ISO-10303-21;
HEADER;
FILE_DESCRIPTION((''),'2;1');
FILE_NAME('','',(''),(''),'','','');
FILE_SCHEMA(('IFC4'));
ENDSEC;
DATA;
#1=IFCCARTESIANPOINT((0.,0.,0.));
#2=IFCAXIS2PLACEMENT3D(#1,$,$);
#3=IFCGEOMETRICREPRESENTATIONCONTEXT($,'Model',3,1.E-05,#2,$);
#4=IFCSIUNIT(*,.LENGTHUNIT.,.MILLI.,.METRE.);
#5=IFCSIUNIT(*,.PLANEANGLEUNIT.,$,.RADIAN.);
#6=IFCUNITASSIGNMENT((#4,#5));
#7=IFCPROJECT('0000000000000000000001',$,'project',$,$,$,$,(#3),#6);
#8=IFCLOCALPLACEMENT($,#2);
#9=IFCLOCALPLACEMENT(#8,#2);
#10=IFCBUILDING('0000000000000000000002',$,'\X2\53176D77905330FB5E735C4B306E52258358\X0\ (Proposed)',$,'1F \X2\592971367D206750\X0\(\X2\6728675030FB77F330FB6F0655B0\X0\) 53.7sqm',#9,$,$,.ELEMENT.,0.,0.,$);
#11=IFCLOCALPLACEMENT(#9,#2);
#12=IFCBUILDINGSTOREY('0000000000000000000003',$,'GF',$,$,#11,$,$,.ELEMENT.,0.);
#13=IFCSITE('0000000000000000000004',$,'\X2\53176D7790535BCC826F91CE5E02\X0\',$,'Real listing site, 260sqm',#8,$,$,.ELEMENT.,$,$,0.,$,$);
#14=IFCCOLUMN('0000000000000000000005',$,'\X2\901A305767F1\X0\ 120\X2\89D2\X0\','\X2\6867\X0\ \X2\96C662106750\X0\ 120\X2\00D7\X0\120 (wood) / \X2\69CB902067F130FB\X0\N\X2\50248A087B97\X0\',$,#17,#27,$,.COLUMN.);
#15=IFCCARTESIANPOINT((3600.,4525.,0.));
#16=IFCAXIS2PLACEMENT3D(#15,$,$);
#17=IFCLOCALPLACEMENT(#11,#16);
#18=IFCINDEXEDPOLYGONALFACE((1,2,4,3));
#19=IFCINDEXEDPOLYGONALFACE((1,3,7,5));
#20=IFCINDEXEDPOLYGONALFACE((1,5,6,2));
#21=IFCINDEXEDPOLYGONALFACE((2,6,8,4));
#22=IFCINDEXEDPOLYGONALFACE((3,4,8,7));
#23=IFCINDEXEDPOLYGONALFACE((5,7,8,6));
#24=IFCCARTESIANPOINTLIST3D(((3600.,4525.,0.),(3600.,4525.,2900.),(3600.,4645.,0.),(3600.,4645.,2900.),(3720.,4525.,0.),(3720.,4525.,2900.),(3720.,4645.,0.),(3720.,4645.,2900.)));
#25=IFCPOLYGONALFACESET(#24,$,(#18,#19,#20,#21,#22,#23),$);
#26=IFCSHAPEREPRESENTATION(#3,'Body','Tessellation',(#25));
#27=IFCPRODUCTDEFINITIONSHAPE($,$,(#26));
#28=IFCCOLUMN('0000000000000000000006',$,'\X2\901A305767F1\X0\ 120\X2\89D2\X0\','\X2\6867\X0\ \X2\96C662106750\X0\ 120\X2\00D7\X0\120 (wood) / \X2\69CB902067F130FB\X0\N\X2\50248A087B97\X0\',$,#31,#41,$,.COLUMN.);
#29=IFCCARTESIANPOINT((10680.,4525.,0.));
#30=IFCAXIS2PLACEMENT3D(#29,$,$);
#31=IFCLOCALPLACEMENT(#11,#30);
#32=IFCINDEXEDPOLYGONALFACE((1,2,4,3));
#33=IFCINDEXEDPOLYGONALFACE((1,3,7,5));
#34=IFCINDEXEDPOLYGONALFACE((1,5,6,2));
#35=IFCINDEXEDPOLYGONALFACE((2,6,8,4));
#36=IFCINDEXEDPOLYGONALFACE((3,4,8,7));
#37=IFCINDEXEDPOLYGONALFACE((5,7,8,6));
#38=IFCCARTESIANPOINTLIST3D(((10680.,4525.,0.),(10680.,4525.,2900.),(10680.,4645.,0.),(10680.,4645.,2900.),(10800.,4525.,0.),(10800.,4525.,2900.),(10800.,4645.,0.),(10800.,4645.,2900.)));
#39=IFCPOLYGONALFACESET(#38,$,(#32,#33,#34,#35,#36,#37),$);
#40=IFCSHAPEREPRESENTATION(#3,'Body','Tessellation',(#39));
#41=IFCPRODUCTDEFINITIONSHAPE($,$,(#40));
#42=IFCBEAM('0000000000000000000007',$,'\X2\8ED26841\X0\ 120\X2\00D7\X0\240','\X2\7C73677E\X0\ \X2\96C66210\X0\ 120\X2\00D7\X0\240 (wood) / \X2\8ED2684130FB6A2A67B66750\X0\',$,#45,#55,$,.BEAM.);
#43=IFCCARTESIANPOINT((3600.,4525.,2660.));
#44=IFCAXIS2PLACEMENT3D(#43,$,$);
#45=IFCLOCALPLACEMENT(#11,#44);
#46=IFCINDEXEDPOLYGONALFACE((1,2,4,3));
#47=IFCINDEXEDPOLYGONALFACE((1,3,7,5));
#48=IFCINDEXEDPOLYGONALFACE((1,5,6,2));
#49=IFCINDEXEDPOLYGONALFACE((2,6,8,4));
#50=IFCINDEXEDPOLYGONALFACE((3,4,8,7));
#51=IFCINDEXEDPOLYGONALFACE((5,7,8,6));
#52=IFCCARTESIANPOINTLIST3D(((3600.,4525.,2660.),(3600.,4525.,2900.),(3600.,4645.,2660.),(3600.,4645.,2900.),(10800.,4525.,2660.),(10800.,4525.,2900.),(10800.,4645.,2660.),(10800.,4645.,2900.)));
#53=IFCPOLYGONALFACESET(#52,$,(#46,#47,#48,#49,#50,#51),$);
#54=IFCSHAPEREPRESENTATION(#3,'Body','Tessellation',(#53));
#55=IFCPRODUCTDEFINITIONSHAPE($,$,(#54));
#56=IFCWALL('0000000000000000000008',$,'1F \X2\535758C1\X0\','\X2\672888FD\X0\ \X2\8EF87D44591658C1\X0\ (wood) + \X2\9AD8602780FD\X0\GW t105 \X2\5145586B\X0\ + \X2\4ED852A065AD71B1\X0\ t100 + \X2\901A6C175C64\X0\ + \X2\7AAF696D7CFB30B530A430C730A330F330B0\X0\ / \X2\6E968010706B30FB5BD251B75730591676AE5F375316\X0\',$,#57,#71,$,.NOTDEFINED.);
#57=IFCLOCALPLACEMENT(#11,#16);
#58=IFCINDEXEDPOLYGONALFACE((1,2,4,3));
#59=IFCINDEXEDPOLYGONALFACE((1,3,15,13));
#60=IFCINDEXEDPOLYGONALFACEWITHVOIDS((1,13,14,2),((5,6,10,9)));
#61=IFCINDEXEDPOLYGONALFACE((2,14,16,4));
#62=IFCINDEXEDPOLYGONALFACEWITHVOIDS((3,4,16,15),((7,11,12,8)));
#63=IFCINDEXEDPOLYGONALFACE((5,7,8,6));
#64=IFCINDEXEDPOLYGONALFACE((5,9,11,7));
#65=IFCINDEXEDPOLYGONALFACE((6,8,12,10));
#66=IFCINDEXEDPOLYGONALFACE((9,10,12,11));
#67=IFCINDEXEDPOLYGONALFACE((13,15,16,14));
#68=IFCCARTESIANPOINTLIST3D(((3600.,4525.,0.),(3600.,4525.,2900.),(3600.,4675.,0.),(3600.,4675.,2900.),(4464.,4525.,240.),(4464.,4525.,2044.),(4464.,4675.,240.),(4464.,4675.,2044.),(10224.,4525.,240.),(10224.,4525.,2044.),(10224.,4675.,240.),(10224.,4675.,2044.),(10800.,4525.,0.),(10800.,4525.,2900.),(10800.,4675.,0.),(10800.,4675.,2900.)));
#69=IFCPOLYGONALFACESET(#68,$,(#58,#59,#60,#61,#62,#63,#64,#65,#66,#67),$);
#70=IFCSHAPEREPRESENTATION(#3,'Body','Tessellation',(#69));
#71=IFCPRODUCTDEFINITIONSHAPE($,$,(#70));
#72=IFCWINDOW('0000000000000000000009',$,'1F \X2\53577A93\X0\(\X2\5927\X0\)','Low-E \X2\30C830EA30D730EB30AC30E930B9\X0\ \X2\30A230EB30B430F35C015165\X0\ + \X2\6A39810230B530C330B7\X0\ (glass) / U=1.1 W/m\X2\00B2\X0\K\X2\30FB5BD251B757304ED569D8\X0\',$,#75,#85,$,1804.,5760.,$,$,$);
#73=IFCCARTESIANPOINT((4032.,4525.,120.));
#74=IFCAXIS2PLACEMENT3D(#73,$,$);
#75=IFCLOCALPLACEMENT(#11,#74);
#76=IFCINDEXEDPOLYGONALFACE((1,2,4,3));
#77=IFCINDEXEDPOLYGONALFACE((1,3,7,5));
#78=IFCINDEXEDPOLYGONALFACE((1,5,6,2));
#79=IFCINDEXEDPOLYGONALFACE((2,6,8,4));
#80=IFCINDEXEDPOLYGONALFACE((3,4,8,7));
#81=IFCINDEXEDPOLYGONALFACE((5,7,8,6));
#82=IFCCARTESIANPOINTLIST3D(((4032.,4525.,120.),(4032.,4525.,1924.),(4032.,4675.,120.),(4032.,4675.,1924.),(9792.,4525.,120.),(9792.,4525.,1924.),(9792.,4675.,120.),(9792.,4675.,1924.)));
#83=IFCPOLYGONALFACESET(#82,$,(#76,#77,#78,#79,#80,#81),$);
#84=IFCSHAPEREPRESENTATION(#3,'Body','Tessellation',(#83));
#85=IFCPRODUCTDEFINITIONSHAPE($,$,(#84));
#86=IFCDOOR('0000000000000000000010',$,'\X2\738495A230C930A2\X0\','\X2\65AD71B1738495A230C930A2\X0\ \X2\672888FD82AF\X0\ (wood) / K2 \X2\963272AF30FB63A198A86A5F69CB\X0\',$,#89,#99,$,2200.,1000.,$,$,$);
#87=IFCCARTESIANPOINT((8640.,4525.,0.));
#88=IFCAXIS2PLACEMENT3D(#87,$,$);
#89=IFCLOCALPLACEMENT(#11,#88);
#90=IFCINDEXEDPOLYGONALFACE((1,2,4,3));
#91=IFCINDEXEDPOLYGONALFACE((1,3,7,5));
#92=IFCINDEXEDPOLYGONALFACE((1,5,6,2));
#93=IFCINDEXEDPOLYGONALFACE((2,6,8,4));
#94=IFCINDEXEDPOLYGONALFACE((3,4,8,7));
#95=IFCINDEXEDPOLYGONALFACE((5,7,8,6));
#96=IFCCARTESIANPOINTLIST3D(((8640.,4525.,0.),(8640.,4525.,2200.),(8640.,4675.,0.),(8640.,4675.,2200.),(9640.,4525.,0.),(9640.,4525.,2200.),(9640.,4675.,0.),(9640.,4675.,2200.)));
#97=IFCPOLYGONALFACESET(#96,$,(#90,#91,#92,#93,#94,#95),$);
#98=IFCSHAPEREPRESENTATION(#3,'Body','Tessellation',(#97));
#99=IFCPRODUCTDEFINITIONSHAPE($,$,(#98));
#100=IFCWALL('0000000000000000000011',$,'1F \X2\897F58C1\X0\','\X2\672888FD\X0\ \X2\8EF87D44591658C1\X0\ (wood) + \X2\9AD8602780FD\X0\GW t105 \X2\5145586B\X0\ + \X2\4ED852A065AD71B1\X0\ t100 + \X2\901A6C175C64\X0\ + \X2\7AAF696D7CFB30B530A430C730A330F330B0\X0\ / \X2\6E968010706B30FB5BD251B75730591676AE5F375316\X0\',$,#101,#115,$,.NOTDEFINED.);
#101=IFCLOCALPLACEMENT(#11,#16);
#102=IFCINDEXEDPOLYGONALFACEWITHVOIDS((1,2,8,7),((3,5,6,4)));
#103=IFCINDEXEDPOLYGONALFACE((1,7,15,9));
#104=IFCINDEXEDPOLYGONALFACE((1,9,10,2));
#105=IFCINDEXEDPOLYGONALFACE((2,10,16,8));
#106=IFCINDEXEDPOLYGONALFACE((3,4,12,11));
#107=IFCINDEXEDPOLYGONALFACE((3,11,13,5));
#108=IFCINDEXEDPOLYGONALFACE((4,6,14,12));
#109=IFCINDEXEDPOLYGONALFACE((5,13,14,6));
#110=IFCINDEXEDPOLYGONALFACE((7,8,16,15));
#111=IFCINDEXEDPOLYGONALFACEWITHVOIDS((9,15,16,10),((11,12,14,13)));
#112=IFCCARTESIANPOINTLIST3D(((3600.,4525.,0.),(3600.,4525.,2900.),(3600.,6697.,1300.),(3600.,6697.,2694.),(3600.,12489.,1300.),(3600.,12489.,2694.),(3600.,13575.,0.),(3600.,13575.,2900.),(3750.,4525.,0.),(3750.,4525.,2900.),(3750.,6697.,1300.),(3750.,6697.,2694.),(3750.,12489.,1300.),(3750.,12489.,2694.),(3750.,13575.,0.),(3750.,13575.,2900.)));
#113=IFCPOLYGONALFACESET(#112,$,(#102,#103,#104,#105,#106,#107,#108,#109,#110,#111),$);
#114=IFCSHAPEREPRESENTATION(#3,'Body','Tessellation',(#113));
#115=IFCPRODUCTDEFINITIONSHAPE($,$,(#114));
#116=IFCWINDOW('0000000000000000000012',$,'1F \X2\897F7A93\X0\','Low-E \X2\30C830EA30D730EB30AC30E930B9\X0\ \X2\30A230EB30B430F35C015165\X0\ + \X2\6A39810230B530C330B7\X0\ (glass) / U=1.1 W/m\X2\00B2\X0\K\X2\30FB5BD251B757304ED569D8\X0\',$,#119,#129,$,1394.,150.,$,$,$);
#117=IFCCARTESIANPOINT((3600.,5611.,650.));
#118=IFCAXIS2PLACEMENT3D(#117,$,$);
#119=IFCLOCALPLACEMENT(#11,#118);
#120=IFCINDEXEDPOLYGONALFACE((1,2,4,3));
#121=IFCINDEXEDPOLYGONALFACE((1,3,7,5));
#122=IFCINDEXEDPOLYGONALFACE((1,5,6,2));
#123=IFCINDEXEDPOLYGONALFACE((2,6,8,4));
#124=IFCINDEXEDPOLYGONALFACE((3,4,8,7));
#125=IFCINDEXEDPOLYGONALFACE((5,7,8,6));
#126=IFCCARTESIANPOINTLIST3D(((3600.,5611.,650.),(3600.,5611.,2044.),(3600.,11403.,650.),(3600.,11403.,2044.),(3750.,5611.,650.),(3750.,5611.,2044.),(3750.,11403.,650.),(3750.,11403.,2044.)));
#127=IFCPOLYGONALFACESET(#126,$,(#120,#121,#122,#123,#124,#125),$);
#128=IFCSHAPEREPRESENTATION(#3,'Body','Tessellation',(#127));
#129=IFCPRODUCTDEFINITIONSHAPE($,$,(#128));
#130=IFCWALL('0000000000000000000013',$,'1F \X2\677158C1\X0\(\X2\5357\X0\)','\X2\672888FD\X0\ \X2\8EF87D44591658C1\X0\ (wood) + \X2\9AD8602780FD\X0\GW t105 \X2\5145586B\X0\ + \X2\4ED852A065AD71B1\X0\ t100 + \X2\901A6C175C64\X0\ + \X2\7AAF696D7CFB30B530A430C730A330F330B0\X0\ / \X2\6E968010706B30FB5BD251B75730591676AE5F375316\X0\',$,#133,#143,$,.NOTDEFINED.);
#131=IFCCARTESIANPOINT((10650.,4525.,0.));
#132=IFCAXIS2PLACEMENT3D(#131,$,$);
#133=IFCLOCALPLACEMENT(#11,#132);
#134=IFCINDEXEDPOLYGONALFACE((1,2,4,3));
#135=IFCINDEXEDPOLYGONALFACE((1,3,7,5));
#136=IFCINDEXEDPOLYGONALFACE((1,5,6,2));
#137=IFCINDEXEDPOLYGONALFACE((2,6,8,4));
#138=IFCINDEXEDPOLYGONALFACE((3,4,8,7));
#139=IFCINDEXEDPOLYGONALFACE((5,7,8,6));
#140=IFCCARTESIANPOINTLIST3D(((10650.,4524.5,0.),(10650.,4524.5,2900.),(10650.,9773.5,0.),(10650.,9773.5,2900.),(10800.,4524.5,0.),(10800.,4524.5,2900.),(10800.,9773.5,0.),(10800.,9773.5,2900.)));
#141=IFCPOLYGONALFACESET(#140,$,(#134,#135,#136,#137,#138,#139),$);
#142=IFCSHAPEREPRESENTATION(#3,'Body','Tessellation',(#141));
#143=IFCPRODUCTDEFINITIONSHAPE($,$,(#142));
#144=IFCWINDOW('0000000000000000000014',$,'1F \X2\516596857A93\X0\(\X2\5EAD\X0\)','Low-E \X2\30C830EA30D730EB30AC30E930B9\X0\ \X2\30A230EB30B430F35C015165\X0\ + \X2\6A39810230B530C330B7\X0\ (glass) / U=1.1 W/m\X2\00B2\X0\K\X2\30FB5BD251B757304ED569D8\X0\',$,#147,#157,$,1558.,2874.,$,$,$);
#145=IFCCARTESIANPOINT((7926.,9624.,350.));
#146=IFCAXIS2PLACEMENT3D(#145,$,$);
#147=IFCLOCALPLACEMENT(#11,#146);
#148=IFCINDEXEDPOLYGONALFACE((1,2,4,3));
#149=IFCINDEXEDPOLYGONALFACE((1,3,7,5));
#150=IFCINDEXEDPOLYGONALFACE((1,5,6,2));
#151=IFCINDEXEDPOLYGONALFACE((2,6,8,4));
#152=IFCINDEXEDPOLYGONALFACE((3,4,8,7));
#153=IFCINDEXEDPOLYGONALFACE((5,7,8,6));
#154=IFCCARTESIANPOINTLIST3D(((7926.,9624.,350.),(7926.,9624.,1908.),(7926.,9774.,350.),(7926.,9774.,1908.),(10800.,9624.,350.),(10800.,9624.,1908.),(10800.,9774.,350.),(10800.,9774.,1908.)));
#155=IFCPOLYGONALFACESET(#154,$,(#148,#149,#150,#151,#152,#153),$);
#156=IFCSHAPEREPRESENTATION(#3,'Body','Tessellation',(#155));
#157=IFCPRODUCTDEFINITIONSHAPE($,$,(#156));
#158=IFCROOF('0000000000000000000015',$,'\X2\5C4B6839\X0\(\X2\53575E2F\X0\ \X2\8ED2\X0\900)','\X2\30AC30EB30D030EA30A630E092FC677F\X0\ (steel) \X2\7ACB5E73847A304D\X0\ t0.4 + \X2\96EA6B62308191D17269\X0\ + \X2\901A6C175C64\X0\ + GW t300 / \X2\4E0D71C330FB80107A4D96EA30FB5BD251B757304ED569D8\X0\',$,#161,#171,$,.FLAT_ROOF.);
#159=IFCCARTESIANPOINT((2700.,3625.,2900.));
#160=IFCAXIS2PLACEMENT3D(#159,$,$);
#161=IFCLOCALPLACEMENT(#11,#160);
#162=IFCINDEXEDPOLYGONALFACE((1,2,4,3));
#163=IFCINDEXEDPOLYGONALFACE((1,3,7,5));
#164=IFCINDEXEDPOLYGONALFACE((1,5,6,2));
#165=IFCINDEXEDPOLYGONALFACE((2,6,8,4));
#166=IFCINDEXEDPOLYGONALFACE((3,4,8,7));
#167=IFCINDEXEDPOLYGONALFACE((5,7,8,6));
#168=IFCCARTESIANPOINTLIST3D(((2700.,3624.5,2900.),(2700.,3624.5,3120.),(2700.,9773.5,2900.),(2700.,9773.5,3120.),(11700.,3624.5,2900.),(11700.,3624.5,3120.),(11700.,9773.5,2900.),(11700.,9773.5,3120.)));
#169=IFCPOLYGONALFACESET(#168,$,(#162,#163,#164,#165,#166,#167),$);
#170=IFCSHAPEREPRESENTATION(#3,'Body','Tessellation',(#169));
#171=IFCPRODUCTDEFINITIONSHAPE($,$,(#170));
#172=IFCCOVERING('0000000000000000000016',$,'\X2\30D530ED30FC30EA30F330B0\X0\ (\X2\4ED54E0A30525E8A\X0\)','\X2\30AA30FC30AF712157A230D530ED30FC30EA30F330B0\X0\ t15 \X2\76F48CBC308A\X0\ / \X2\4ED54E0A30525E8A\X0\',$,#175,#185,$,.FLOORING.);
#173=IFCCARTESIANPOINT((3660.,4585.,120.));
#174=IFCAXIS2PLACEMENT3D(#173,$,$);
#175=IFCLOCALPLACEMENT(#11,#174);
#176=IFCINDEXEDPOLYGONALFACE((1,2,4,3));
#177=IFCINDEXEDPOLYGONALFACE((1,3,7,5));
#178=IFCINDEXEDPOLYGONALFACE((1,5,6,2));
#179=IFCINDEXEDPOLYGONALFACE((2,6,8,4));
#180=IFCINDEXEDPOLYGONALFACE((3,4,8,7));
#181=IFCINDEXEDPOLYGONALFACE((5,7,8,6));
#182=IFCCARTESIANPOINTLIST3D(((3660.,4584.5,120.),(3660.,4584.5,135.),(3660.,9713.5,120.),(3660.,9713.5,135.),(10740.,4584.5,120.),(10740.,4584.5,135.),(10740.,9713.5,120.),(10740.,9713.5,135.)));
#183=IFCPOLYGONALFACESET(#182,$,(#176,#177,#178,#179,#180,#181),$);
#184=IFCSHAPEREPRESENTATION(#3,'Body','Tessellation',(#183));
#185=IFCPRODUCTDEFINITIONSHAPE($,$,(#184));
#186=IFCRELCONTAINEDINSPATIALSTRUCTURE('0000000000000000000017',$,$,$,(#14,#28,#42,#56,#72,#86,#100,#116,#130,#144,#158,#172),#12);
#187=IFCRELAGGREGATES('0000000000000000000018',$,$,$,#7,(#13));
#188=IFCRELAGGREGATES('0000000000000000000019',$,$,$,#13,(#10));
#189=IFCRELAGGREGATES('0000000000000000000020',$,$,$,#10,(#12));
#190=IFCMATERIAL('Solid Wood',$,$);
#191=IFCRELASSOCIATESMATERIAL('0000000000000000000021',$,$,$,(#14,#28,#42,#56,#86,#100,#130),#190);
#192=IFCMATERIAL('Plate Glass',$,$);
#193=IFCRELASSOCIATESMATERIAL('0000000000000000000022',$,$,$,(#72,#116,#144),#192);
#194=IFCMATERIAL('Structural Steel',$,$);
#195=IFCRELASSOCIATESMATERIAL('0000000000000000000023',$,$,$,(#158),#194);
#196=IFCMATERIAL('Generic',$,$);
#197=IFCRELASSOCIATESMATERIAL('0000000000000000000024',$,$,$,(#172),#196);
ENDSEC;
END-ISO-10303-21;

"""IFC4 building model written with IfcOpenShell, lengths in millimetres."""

from ifc_helpers import new_model, si_unit, frame, frame_2d, origin, place, context, project, spatial, rectangle, extrude, material, element, fill, save


model = new_model("IFC4")

# Units and contexts
model_context = context("Model", 3, precision=1e-05, world=origin())
ifc_project = project(units=[si_unit("LENGTHUNIT", "METRE", prefix="MILLI"), si_unit("PLANEANGLEUNIT", "RADIAN")], contexts=[model_context])

# Site, building, storey
site_placement = place(None, origin())
site = spatial("IfcSite", under=ifc_project, at=site_placement, Name="北海道富良野市", ObjectType="Real listing site, 260sqm", CompositionType="ELEMENT", RefElevation=0.0)
building_placement = place(site_placement, origin())
building = spatial("IfcBuilding", under=site, at=building_placement, Name="北海道・平屋の別荘 (Proposed)", ObjectType="1F 天然素材(木材・石・漆喰) 53.7sqm", CompositionType="ELEMENT", ElevationOfRefHeight=0.0, ElevationOfTerrain=0.0)
storey_placement = place(building_placement, origin())
storey = spatial("IfcBuildingStorey", under=building, at=storey_placement, Name="GF", CompositionType="ELEMENT", Elevation=0.0)

# Columns
ifc_material_1 = material(Name="Solid Wood")
column_1_placement = place(storey_placement, frame((3600.0, 4525.0, 0.0)))
element("IfcColumn", 1, at=column_1_placement, inside=storey, material=ifc_material_1, Name="通し柱 120角", Description="桧 集成材 120×120 (wood) / 構造柱・N値計算", PredefinedType="COLUMN", context=model_context, shape_type="SweptSolid", body=[
    extrude(rectangle(XDim=120.0, YDim=120.0, at=frame_2d((60.0, 60.0))), frame((3600.0, 4525.0, 0.0)), (0.0, 0.0, 1.0), 2900.0),
])
column_2_placement = place(storey_placement, frame((10680.0, 4525.0, 0.0)))
element("IfcColumn", 2, at=column_2_placement, inside=storey, material=ifc_material_1, Name="通し柱 120角", Description="桧 集成材 120×120 (wood) / 構造柱・N値計算", PredefinedType="COLUMN", context=model_context, shape_type="SweptSolid", body=[
    extrude(rectangle(XDim=120.0, YDim=120.0, at=frame_2d((60.0, 60.0))), frame((10680.0, 4525.0, 0.0)), (0.0, 0.0, 1.0), 2900.0),
])

# Beam
beam_1_placement = place(storey_placement, frame((3600.0, 4525.0, 2660.0)))
element("IfcBeam", 3, at=beam_1_placement, inside=storey, material=ifc_material_1, Name="軒桁 120×240", Description="米松 集成 120×240 (wood) / 軒桁・横架材", PredefinedType="BEAM", context=model_context, shape_type="SweptSolid", body=[
    extrude(rectangle(XDim=7200.0, YDim=120.0, at=frame_2d((3600.0, 60.0))), frame((3600.0, 4525.0, 2660.0)), (0.0, 0.0, 1.0), 240.0),
])

# Wall, openings, window, door
wall_1_placement = place(storey_placement, frame((3600.0, 4525.0, 0.0)))
wall_1 = element("IfcWall", 4, at=wall_1_placement, inside=storey, material=ifc_material_1, Name="1F 南壁", Description="木製 軸組外壁 (wood) + 高性能GW t105 充填 + 付加断熱 t100 + 通気層 + 窯業系サイディング / 準耐火・寒冷地外皮強化", PredefinedType="NOTDEFINED", context=model_context, shape_type="SweptSolid", body=[
    extrude(rectangle(XDim=7200.0, YDim=150.0, at=frame_2d((3600.0, 75.0))), frame((3600.0, 4525.0, 0.0)), (0.0, 0.0, 1.0), 2900.0),
])
opening_1_placement = place(storey_placement, frame((4032.0, 4525.0, 120.0)))
opening_1 = element("IfcOpeningElement", 5, at=opening_1_placement, cuts=wall_1, PredefinedType="NOTDEFINED", context=model_context, shape_type="SweptSolid", body=[
    extrude(rectangle(XDim=5760.0, YDim=150.0, at=frame_2d((2880.0, 75.0))), frame((4032.0, 4525.0, 120.0)), (0.0, 0.0, 1.0), 1804.0),
])
opening_2_placement = place(storey_placement, frame((8640.0, 4525.0, 0.0)))
opening_2 = element("IfcOpeningElement", 6, at=opening_2_placement, cuts=wall_1, PredefinedType="NOTDEFINED", context=model_context, shape_type="SweptSolid", body=[
    extrude(rectangle(XDim=1000.0, YDim=150.0, at=frame_2d((500.0, 75.0))), frame((8640.0, 4525.0, 0.0)), (0.0, 0.0, 1.0), 2200.0),
])
ifc_material_2 = material(Name="Plate Glass")
window_1_placement = place(storey_placement, frame((4032.0, 4525.0, 120.0)))
window_1 = element("IfcWindow", 7, at=window_1_placement, inside=storey, material=ifc_material_2, Name="1F 南窓(大)", Description="Low-E トリプルガラス アルゴン封入 + 樹脂サッシ (glass) / U=1.1 W/m²K・寒冷地仕様", OverallHeight=1804.0, OverallWidth=5760.0, context=model_context, shape_type="SweptSolid", body=[
    extrude(rectangle(XDim=5760.0, YDim=150.0, at=frame_2d((2880.0, 75.0))), frame((4032.0, 4525.0, 120.0)), (0.0, 0.0, 1.0), 1804.0),
])
fill(opening_1, window_1)
door_1_placement = place(storey_placement, frame((8640.0, 4525.0, 0.0)))
door_1 = element("IfcDoor", 8, at=door_1_placement, inside=storey, material=ifc_material_1, Name="玄関ドア", Description="断熱玄関ドア 木製芯 (wood) / K2 防犯・採風機構", OverallHeight=2200.0, OverallWidth=1000.0, context=model_context, shape_type="SweptSolid", body=[
    extrude(rectangle(XDim=1000.0, YDim=150.0, at=frame_2d((500.0, 75.0))), frame((8640.0, 4525.0, 0.0)), (0.0, 0.0, 1.0), 2200.0),
])
fill(opening_2, door_1)

# Walls, openings, windows
wall_2_placement = place(storey_placement, frame((3600.0, 4525.0, 0.0)))
wall_2 = element("IfcWall", 9, at=wall_2_placement, inside=storey, material=ifc_material_1, Name="1F 西壁", Description="木製 軸組外壁 (wood) + 高性能GW t105 充填 + 付加断熱 t100 + 通気層 + 窯業系サイディング / 準耐火・寒冷地外皮強化", PredefinedType="NOTDEFINED", context=model_context, shape_type="SweptSolid", body=[
    extrude(rectangle(XDim=150.0, YDim=9050.0, at=frame_2d((75.0, 4525.0))), frame((3600.0, 4525.0, 0.0)), (0.0, 0.0, 1.0), 2900.0),
])
opening_3_placement = place(storey_placement, frame((3600.0, 5611.0, 650.0)))
opening_3 = element("IfcOpeningElement", 10, at=opening_3_placement, cuts=wall_2, PredefinedType="NOTDEFINED", context=model_context, shape_type="SweptSolid", body=[
    extrude(rectangle(XDim=150.0, YDim=5792.0, at=frame_2d((75.0, 2896.0))), frame((3600.0, 5611.0, 650.0)), (0.0, 0.0, 1.0), 1394.0),
])
window_2_placement = place(storey_placement, frame((3600.0, 5611.0, 650.0)))
window_2 = element("IfcWindow", 11, at=window_2_placement, inside=storey, material=ifc_material_2, Name="1F 西窓", Description="Low-E トリプルガラス アルゴン封入 + 樹脂サッシ (glass) / U=1.1 W/m²K・寒冷地仕様", OverallHeight=1394.0, OverallWidth=150.0, context=model_context, shape_type="SweptSolid", body=[
    extrude(rectangle(XDim=150.0, YDim=5792.0, at=frame_2d((75.0, 2896.0))), frame((3600.0, 5611.0, 650.0)), (0.0, 0.0, 1.0), 1394.0),
])
fill(opening_3, window_2)
wall_3_placement = place(storey_placement, frame((10650.0, 4525.0, 0.0)))
wall_3 = element("IfcWall", 12, at=wall_3_placement, inside=storey, material=ifc_material_1, Name="1F 東壁(南)", Description="木製 軸組外壁 (wood) + 高性能GW t105 充填 + 付加断熱 t100 + 通気層 + 窯業系サイディング / 準耐火・寒冷地外皮強化", PredefinedType="NOTDEFINED", context=model_context, shape_type="SweptSolid", body=[
    extrude(rectangle(XDim=150.0, YDim=5249.0, at=frame_2d((75.0, 2624.0))), frame((10650.0, 4525.0, 0.0)), (0.0, 0.0, 1.0), 2900.0),
])
opening_4_placement = place(storey_placement, frame((7926.0, 9624.0, 350.0)))
opening_4 = element("IfcOpeningElement", 13, at=opening_4_placement, cuts=wall_3, PredefinedType="NOTDEFINED", context=model_context, shape_type="SweptSolid", body=[
    extrude(rectangle(XDim=2874.0, YDim=150.0, at=frame_2d((1437.0, 75.0))), frame((7926.0, 9624.0, 350.0)), (0.0, 0.0, 1.0), 1558.0),
])
window_3_placement = place(storey_placement, frame((7926.0, 9624.0, 350.0)))
window_3 = element("IfcWindow", 14, at=window_3_placement, inside=storey, material=ifc_material_2, Name="1F 入隅窓(庭)", Description="Low-E トリプルガラス アルゴン封入 + 樹脂サッシ (glass) / U=1.1 W/m²K・寒冷地仕様", OverallHeight=1558.0, OverallWidth=2874.0, context=model_context, shape_type="SweptSolid", body=[
    extrude(rectangle(XDim=2874.0, YDim=150.0, at=frame_2d((1437.0, 75.0))), frame((7926.0, 9624.0, 350.0)), (0.0, 0.0, 1.0), 1558.0),
])
fill(opening_4, window_3)

# Roof
ifc_material_3 = material(Name="Structural Steel")
roof_placement = place(storey_placement, frame((2700.0, 3625.0, 2900.0)))
element("IfcRoof", 15, at=roof_placement, inside=storey, material=ifc_material_3, Name="屋根(南帯 軒900)", Description="ガルバリウム鋼板 (steel) 立平葺き t0.4 + 雪止め金物 + 通気層 + GW t300 / 不燃・耐積雪・寒冷地仕様", PredefinedType="FLAT_ROOF", context=model_context, shape_type="SweptSolid", body=[
    extrude(rectangle(XDim=9000.0, YDim=6149.0, at=frame_2d((4500.0, 3074.0))), frame((2700.0, 3625.0, 2900.0)), (0.0, 0.0, 1.0), 220.0),
])

# Covering
ifc_material_4 = material(Name="Generic")
covering_1_placement = place(storey_placement, frame((3660.0, 4585.0, 120.0)))
element("IfcCovering", 16, at=covering_1_placement, inside=storey, material=ifc_material_4, Name="フローリング (仕上げ床)", Description="オーク無垢フローリング t15 直貼り / 仕上げ床", PredefinedType="FLOORING", context=model_context, shape_type="SweptSolid", body=[
    extrude(rectangle(XDim=7080.0, YDim=5129.0, at=frame_2d((3540.0, 2564.0))), frame((3660.0, 4585.0, 120.0)), (0.0, 0.0, 1.0), 15.0),
])

save(model, "model.ifc")
